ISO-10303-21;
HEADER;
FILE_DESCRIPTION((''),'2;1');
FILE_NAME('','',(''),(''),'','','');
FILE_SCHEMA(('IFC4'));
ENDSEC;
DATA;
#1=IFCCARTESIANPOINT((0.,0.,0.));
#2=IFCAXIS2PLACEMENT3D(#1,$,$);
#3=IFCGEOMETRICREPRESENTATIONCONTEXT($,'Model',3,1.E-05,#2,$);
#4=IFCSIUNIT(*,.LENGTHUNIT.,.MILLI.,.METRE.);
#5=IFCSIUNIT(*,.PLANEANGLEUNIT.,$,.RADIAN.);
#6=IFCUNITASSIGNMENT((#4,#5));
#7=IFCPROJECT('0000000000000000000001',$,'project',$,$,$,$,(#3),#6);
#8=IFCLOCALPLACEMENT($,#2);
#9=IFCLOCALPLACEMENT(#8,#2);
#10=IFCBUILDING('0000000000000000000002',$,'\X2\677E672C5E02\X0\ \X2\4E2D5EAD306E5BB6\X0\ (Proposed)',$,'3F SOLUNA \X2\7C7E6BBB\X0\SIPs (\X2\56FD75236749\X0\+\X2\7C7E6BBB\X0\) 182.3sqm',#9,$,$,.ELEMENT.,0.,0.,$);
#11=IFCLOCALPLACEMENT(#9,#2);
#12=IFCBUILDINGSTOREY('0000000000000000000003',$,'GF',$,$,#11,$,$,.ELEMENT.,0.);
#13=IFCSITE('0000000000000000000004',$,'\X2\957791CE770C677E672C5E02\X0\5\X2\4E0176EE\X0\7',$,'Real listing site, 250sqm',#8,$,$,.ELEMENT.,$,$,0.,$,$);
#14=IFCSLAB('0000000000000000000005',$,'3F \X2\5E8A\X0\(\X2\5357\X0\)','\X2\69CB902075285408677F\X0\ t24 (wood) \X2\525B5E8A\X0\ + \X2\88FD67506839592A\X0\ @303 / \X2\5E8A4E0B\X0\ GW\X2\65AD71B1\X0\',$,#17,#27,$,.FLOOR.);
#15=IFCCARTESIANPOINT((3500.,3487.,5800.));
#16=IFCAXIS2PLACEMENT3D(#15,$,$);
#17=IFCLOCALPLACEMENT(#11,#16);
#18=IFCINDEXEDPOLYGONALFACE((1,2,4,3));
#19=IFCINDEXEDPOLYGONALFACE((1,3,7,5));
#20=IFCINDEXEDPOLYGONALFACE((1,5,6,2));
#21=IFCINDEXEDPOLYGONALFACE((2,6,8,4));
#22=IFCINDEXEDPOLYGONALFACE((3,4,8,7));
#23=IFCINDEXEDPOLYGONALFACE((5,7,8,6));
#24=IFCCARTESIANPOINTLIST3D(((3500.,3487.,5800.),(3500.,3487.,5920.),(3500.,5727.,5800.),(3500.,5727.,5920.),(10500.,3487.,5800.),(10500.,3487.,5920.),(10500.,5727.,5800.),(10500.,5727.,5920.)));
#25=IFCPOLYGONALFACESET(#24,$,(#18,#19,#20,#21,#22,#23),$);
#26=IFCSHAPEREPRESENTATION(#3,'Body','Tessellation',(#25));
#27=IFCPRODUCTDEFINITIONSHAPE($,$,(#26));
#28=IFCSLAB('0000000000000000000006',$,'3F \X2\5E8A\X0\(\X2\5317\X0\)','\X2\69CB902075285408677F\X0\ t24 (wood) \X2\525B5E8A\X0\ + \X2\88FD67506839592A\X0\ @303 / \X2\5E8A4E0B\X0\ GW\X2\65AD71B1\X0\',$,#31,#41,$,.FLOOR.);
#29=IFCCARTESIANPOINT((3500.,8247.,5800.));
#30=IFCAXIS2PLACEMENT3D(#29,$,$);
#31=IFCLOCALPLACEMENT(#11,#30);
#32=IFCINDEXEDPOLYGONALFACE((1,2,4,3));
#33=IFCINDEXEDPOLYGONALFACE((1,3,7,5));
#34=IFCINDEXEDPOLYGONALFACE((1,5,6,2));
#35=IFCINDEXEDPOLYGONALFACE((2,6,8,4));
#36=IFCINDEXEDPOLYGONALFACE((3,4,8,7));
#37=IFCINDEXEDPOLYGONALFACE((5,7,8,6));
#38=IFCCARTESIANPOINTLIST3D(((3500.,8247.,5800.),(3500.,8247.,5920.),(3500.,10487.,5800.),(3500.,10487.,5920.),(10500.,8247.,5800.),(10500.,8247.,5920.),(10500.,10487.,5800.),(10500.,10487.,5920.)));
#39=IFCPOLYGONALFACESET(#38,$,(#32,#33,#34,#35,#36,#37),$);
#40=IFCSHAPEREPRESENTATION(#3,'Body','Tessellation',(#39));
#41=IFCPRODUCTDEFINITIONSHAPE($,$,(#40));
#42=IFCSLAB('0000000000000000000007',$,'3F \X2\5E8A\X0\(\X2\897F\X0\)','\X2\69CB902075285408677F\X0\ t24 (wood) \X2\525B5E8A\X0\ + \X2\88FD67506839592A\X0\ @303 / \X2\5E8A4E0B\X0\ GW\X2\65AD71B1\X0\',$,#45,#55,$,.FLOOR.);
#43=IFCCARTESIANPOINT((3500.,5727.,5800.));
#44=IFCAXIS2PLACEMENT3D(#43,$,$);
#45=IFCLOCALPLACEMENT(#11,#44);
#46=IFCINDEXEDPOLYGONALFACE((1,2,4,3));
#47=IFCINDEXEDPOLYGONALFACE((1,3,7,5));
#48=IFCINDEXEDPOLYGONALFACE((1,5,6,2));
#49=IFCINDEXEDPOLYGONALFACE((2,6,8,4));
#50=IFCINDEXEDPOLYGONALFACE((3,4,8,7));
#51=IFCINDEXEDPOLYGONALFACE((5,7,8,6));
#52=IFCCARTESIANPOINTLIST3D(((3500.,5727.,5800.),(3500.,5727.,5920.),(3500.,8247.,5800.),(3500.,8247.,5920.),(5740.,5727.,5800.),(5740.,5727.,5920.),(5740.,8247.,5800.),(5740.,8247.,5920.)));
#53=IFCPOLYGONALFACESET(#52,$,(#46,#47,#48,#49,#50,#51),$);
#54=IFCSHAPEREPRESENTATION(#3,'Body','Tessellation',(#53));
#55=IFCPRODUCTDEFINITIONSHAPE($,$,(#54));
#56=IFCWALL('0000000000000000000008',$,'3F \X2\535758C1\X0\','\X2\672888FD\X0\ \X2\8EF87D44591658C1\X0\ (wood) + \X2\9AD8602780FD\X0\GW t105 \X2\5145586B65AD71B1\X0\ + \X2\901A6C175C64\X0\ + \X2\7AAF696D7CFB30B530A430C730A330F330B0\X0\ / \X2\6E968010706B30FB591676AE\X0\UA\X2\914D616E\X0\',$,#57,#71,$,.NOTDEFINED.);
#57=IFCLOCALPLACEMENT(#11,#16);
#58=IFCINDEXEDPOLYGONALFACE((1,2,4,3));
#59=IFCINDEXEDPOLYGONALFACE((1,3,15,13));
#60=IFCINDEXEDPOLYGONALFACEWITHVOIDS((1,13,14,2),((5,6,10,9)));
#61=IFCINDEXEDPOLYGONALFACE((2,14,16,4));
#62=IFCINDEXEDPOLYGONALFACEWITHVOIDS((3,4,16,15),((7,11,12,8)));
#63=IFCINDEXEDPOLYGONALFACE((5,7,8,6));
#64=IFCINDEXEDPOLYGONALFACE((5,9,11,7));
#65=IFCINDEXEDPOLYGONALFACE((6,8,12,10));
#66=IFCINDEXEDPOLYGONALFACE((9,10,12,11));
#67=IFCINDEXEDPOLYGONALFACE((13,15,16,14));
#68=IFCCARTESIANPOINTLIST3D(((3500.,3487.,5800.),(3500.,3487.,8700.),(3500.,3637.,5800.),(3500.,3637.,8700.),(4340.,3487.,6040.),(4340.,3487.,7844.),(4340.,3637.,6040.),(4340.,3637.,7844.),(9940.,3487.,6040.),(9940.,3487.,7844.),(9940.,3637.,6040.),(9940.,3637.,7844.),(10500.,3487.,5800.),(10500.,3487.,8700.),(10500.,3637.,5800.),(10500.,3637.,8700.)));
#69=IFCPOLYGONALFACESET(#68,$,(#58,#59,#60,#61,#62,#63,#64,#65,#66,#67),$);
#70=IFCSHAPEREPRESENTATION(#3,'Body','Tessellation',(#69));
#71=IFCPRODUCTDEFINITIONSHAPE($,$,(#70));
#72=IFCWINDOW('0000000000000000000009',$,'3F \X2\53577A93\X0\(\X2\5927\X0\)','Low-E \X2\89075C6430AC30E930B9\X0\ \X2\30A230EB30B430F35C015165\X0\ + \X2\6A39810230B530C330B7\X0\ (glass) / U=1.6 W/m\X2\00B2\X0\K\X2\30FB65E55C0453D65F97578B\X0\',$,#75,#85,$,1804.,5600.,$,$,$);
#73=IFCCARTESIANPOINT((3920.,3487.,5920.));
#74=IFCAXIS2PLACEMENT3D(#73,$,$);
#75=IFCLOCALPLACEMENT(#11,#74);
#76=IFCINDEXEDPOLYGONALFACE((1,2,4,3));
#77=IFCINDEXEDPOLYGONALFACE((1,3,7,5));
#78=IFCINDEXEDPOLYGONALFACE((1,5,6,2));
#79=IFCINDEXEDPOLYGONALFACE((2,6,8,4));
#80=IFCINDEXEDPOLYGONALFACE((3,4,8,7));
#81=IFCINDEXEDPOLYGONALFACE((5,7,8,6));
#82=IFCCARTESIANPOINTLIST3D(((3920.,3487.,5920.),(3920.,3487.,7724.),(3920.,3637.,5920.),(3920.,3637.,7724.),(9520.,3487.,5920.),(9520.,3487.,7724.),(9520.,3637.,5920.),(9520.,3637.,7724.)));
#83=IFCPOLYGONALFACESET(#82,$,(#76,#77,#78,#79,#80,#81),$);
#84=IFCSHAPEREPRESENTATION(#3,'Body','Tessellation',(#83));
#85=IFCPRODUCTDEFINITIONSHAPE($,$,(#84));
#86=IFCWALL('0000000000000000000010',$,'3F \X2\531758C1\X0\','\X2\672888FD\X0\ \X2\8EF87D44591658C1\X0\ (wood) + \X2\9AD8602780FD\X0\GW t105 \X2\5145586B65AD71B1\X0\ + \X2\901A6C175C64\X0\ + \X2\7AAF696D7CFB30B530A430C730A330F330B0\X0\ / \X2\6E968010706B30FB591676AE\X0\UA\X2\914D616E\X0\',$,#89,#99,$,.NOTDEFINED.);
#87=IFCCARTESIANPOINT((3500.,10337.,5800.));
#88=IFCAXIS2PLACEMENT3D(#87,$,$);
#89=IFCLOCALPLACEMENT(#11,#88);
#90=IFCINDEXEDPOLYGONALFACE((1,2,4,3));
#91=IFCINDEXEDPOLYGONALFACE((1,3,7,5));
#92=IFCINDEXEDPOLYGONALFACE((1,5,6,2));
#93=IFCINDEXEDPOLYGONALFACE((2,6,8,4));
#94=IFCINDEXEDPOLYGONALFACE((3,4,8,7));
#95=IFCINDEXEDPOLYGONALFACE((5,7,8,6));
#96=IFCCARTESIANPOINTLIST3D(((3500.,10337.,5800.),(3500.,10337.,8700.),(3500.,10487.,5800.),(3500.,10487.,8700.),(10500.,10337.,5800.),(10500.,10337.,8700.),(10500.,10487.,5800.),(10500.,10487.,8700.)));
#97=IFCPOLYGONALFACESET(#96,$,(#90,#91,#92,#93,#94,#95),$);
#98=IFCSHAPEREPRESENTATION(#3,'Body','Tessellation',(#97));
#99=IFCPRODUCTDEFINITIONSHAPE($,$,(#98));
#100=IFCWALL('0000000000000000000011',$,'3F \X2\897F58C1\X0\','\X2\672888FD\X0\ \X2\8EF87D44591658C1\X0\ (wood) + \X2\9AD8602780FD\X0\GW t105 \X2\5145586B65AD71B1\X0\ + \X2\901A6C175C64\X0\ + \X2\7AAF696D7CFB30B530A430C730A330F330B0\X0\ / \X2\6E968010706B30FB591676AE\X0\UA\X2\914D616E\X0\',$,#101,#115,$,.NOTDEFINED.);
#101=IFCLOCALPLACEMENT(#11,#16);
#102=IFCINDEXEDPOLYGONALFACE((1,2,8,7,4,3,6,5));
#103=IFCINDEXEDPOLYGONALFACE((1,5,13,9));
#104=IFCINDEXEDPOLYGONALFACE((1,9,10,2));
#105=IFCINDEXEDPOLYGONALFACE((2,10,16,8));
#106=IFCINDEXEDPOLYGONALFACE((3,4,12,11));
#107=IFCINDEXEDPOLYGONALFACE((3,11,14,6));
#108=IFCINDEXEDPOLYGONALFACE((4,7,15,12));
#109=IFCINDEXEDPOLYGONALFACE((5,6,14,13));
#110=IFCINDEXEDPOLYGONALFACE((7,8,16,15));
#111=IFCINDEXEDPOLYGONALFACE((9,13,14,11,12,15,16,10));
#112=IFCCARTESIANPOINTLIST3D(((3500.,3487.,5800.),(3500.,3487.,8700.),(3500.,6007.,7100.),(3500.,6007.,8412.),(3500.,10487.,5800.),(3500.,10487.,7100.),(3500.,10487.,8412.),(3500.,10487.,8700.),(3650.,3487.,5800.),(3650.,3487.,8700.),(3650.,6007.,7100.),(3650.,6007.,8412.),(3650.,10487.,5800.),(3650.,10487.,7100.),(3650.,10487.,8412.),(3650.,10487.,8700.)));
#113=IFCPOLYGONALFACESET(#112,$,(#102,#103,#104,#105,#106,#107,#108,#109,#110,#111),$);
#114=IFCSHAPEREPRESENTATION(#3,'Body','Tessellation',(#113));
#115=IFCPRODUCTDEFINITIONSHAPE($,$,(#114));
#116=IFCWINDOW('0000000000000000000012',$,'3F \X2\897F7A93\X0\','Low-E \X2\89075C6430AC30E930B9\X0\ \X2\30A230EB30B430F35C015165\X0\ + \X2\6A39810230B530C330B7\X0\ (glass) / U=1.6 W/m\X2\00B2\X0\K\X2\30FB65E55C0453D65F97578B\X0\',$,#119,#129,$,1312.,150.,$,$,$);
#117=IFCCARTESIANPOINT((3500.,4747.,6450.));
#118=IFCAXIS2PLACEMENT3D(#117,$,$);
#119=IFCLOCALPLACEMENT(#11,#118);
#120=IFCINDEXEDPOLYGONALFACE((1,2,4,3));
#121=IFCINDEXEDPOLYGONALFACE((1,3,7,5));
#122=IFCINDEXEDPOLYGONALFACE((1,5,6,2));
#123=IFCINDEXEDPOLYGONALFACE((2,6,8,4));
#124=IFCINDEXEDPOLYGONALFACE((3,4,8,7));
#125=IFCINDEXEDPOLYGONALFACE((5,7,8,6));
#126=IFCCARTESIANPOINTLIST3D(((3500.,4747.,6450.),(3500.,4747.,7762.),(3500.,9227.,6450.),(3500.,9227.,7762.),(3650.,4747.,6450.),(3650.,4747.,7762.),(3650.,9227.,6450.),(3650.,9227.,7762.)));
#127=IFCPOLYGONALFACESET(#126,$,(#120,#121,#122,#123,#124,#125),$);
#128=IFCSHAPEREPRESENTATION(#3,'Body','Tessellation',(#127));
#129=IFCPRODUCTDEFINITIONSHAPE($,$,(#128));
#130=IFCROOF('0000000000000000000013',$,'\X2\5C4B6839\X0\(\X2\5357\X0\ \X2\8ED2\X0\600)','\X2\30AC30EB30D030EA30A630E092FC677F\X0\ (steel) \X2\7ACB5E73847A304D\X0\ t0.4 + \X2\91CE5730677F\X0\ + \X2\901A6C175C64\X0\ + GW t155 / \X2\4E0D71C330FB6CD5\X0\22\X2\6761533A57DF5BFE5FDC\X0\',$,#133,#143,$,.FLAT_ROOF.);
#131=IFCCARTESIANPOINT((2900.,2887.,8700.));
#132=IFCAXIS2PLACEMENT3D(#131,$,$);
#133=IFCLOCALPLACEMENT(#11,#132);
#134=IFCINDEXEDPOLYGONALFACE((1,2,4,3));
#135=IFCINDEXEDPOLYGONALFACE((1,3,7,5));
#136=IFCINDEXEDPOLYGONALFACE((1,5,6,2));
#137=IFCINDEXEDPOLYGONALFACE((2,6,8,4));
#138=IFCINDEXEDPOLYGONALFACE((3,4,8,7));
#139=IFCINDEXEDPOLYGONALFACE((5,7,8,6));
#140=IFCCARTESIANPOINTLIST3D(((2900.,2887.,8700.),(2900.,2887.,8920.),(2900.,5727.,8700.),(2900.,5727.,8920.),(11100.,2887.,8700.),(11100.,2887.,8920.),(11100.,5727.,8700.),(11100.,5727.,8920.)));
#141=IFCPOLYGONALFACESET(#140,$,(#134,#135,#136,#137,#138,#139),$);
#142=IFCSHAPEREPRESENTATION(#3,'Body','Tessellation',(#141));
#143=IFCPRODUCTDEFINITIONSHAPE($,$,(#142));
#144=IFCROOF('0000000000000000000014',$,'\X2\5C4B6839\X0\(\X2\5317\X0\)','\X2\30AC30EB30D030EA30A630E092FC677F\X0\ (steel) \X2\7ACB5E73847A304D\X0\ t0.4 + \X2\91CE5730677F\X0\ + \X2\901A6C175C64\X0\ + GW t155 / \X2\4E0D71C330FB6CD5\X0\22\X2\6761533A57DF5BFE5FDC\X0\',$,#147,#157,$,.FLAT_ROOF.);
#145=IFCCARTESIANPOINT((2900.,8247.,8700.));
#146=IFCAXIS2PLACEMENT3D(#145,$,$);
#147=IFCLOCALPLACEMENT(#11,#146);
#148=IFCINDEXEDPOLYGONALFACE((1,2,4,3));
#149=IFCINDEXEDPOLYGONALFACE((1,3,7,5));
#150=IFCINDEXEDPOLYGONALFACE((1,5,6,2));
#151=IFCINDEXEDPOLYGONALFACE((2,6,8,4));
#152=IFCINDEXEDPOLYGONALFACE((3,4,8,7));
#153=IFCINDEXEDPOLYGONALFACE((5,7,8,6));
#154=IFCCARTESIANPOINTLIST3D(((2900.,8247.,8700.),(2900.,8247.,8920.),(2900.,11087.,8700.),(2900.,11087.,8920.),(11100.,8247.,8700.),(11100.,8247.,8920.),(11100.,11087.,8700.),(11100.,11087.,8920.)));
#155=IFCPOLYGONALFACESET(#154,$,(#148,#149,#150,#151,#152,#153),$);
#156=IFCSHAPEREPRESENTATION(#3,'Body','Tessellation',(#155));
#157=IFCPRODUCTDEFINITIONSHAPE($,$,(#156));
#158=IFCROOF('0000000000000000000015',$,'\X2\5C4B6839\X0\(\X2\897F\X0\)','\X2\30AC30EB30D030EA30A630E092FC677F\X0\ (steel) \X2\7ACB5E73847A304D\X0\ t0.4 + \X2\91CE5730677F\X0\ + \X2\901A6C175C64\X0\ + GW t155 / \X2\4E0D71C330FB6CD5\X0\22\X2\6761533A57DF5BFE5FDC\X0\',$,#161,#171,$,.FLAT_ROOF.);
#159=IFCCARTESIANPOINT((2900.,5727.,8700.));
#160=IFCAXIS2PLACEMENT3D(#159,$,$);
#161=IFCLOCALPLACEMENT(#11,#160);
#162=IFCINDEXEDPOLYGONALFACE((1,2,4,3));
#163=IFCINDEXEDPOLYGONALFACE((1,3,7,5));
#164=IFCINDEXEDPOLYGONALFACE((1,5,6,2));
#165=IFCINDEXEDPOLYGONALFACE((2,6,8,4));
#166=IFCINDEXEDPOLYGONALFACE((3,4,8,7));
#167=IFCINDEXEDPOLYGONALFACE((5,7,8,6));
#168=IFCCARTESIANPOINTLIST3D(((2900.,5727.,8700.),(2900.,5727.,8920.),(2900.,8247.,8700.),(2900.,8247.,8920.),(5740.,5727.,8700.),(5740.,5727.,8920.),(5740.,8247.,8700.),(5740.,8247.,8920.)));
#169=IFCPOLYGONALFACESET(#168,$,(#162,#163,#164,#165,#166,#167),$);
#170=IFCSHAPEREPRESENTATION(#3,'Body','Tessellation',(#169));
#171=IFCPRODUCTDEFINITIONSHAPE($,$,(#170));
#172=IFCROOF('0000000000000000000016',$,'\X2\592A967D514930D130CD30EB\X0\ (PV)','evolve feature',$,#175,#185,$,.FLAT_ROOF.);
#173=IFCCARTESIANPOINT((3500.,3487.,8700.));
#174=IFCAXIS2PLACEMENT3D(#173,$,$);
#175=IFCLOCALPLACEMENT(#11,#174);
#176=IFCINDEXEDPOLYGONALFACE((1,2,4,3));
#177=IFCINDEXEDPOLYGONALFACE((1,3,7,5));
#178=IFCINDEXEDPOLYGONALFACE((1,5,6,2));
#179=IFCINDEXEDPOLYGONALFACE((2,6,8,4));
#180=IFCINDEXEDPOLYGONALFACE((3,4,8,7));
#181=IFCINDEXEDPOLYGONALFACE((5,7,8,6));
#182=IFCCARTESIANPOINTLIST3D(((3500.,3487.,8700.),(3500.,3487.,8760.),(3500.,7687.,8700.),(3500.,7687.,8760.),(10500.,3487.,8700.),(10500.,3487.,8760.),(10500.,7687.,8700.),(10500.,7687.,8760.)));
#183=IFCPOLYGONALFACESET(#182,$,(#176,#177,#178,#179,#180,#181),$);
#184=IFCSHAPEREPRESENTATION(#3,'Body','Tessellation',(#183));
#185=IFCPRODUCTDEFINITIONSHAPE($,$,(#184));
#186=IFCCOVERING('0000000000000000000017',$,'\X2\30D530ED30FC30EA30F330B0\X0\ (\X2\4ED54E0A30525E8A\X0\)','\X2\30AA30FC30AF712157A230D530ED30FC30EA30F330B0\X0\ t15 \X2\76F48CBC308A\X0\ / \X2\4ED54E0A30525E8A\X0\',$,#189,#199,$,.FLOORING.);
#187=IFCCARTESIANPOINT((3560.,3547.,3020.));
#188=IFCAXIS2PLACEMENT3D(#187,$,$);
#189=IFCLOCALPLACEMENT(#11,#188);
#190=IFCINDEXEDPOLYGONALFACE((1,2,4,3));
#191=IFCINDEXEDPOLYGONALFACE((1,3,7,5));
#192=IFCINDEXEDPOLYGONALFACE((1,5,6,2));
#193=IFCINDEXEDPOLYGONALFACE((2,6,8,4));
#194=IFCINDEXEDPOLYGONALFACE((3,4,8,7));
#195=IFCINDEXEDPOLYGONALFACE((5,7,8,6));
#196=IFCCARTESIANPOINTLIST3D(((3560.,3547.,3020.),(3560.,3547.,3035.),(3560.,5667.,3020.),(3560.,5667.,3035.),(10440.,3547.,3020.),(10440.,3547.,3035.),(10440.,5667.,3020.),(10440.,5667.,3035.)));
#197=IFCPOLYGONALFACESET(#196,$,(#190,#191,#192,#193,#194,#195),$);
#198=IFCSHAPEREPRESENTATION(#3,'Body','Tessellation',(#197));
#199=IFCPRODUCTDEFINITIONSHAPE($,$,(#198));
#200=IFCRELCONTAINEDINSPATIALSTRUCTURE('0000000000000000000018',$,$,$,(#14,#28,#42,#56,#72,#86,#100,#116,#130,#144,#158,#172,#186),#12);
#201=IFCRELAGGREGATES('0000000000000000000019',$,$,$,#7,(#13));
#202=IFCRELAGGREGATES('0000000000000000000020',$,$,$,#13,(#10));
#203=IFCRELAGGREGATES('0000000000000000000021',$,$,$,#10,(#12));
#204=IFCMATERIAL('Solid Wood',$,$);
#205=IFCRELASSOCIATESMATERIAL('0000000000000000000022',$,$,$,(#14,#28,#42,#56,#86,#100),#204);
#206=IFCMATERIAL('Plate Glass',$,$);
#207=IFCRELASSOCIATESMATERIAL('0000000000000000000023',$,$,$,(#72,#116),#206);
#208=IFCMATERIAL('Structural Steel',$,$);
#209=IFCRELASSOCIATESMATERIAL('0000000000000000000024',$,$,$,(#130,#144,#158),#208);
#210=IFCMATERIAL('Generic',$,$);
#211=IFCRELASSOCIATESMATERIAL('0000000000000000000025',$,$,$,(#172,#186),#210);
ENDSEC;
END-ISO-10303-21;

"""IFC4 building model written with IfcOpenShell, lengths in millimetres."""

from ifc_helpers import new_model, si_unit, frame, frame_2d, origin, place, context, project, spatial, rectangle, extrude, material, element, fill, save


model = new_model("IFC4")

# Units and contexts
model_context = context("Model", 3, precision=1e-05, world=origin())
ifc_project = project(units=[si_unit("LENGTHUNIT", "METRE", prefix="MILLI"), si_unit("PLANEANGLEUNIT", "RADIAN")], contexts=[model_context])

# Site, building, storey
site_placement = place(None, origin())
site = spatial("IfcSite", under=ifc_project, at=site_placement, Name="長野県松本市5丁目7", ObjectType="Real listing site, 250sqm", CompositionType="ELEMENT", RefElevation=0.0)
building_placement = place(site_placement, origin())
building = spatial("IfcBuilding", under=site, at=building_placement, Name="松本市 中庭の家 (Proposed)", ObjectType="3F SOLUNA 籾殻SIPs (国産杉+籾殻) 182.3sqm", CompositionType="ELEMENT", ElevationOfRefHeight=0.0, ElevationOfTerrain=0.0)
storey_placement = place(building_placement, origin())
storey = spatial("IfcBuildingStorey", under=building, at=storey_placement, Name="GF", CompositionType="ELEMENT", Elevation=0.0)

# Slabs
ifc_material_1 = material(Name="Solid Wood")
slab_1_placement = place(storey_placement, frame((3500.0, 3487.0, 5800.0)))
element("IfcSlab", 1, at=slab_1_placement, inside=storey, material=ifc_material_1, Name="3F 床(南)", Description="構造用合板 t24 (wood) 剛床 + 製材根太 @303 / 床下 GW断熱", PredefinedType="FLOOR", context=model_context, shape_type="SweptSolid", body=[
    extrude(rectangle(XDim=7000.0, YDim=2240.0, at=frame_2d((3500.0, 1120.0))), frame((3500.0, 3487.0, 5800.0)), (0.0, 0.0, 1.0), 120.0),
])
slab_2_placement = place(storey_placement, frame((3500.0, 8247.0, 5800.0)))
element("IfcSlab", 2, at=slab_2_placement, inside=storey, material=ifc_material_1, Name="3F 床(北)", Description="構造用合板 t24 (wood) 剛床 + 製材根太 @303 / 床下 GW断熱", PredefinedType="FLOOR", context=model_context, shape_type="SweptSolid", body=[
    extrude(rectangle(XDim=7000.0, YDim=2240.0, at=frame_2d((3500.0, 1120.0))), frame((3500.0, 8247.0, 5800.0)), (0.0, 0.0, 1.0), 120.0),
])
slab_3_placement = place(storey_placement, frame((3500.0, 5727.0, 5800.0)))
element("IfcSlab", 3, at=slab_3_placement, inside=storey, material=ifc_material_1, Name="3F 床(西)", Description="構造用合板 t24 (wood) 剛床 + 製材根太 @303 / 床下 GW断熱", PredefinedType="FLOOR", context=model_context, shape_type="SweptSolid", body=[
    extrude(rectangle(XDim=2240.0, YDim=2520.0, at=frame_2d((1120.0, 1260.0))), frame((3500.0, 5727.0, 5800.0)), (0.0, 0.0, 1.0), 120.0),
])

# Wall, opening, window
wall_1_placement = place(storey_placement, frame((3500.0, 3487.0, 5800.0)))
wall_1 = element("IfcWall", 4, at=wall_1_placement, inside=storey, material=ifc_material_1, Name="3F 南壁", Description="木製 軸組外壁 (wood) + 高性能GW t105 充填断熱 + 通気層 + 窯業系サイディング / 準耐火・外皮UA配慮", PredefinedType="NOTDEFINED", context=model_context, shape_type="SweptSolid", body=[
    extrude(rectangle(XDim=7000.0, YDim=150.0, at=frame_2d((3500.0, 75.0))), frame((3500.0, 3487.0, 5800.0)), (0.0, 0.0, 1.0), 2900.0),
])
opening_1_placement = place(storey_placement, frame((3920.0, 3487.0, 5920.0)))
opening_1 = element("IfcOpeningElement", 5, at=opening_1_placement, cuts=wall_1, PredefinedType="NOTDEFINED", context=model_context, shape_type="SweptSolid", body=[
    extrude(rectangle(XDim=5600.0, YDim=150.0, at=frame_2d((2800.0, 75.0))), frame((3920.0, 3487.0, 5920.0)), (0.0, 0.0, 1.0), 1804.0),
])
ifc_material_2 = material(Name="Plate Glass")
window_1_placement = place(storey_placement, frame((3920.0, 3487.0, 5920.0)))
window_1 = element("IfcWindow", 6, at=window_1_placement, inside=storey, material=ifc_material_2, Name="3F 南窓(大)", Description="Low-E 複層ガラス アルゴン封入 + 樹脂サッシ (glass) / U=1.6 W/m²K・日射取得型", OverallHeight=1804.0, OverallWidth=5600.0, context=model_context, shape_type="SweptSolid", body=[
    extrude(rectangle(XDim=5600.0, YDim=150.0, at=frame_2d((2800.0, 75.0))), frame((3920.0, 3487.0, 5920.0)), (0.0, 0.0, 1.0), 1804.0),
])
fill(opening_1, window_1)

# Wall
wall_2_placement = place(storey_placement, frame((3500.0, 10337.0, 5800.0)))
element("IfcWall", 7, at=wall_2_placement, inside=storey, material=ifc_material_1, Name="3F 北壁", Description="木製 軸組外壁 (wood) + 高性能GW t105 充填断熱 + 通気層 + 窯業系サイディング / 準耐火・外皮UA配慮", PredefinedType="NOTDEFINED", context=model_context, shape_type="SweptSolid", body=[
    extrude(rectangle(XDim=7000.0, YDim=150.0, at=frame_2d((3500.0, 75.0))), frame((3500.0, 10337.0, 5800.0)), (0.0, 0.0, 1.0), 2900.0),
])

# Wall, opening, window
wall_3_placement = place(storey_placement, frame((3500.0, 3487.0, 5800.0)))
wall_3 = element("IfcWall", 8, at=wall_3_placement, inside=storey, material=ifc_material_1, Name="3F 西壁", Description="木製 軸組外壁 (wood) + 高性能GW t105 充填断熱 + 通気層 + 窯業系サイディング / 準耐火・外皮UA配慮", PredefinedType="NOTDEFINED", context=model_context, shape_type="SweptSolid", body=[
    extrude(rectangle(XDim=150.0, YDim=7000.0, at=frame_2d((75.0, 3500.0))), frame((3500.0, 3487.0, 5800.0)), (0.0, 0.0, 1.0), 2900.0),
])
opening_2_placement = place(storey_placement, frame((3500.0, 4747.0, 6450.0)))
opening_2 = element("IfcOpeningElement", 9, at=opening_2_placement, cuts=wall_3, PredefinedType="NOTDEFINED", context=model_context, shape_type="SweptSolid", body=[
    extrude(rectangle(XDim=150.0, YDim=4480.0, at=frame_2d((75.0, 2240.0))), frame((3500.0, 4747.0, 6450.0)), (0.0, 0.0, 1.0), 1312.0),
])
window_2_placement = place(storey_placement, frame((3500.0, 4747.0, 6450.0)))
window_2 = element("IfcWindow", 10, at=window_2_placement, inside=storey, material=ifc_material_2, Name="3F 西窓", Description="Low-E 複層ガラス アルゴン封入 + 樹脂サッシ (glass) / U=1.6 W/m²K・日射取得型", OverallHeight=1312.0, OverallWidth=150.0, context=model_context, shape_type="SweptSolid", body=[
    extrude(rectangle(XDim=150.0, YDim=4480.0, at=frame_2d((75.0, 2240.0))), frame((3500.0, 4747.0, 6450.0)), (0.0, 0.0, 1.0), 1312.0),
])
fill(opening_2, window_2)

# Roofs
ifc_material_3 = material(Name="Structural Steel")
roof_1_placement = place(storey_placement, frame((2900.0, 2887.0, 8700.0)))
element("IfcRoof", 11, at=roof_1_placement, inside=storey, material=ifc_material_3, Name="屋根(南 軒600)", Description="ガルバリウム鋼板 (steel) 立平葺き t0.4 + 野地板 + 通気層 + GW t155 / 不燃・法22条区域対応", PredefinedType="FLAT_ROOF", context=model_context, shape_type="SweptSolid", body=[
    extrude(rectangle(XDim=8200.0, YDim=2840.0, at=frame_2d((4100.0, 1420.0))), frame((2900.0, 2887.0, 8700.0)), (0.0, 0.0, 1.0), 220.0),
])
roof_2_placement = place(storey_placement, frame((2900.0, 8247.0, 8700.0)))
element("IfcRoof", 12, at=roof_2_placement, inside=storey, material=ifc_material_3, Name="屋根(北)", Description="ガルバリウム鋼板 (steel) 立平葺き t0.4 + 野地板 + 通気層 + GW t155 / 不燃・法22条区域対応", PredefinedType="FLAT_ROOF", context=model_context, shape_type="SweptSolid", body=[
    extrude(rectangle(XDim=8200.0, YDim=2840.0, at=frame_2d((4100.0, 1420.0))), frame((2900.0, 8247.0, 8700.0)), (0.0, 0.0, 1.0), 220.0),
])
roof_3_placement = place(storey_placement, frame((2900.0, 5727.0, 8700.0)))
element("IfcRoof", 13, at=roof_3_placement, inside=storey, material=ifc_material_3, Name="屋根(西)", Description="ガルバリウム鋼板 (steel) 立平葺き t0.4 + 野地板 + 通気層 + GW t155 / 不燃・法22条区域対応", PredefinedType="FLAT_ROOF", context=model_context, shape_type="SweptSolid", body=[
    extrude(rectangle(XDim=2840.0, YDim=2520.0, at=frame_2d((1420.0, 1260.0))), frame((2900.0, 5727.0, 8700.0)), (0.0, 0.0, 1.0), 220.0),
])
ifc_material_4 = material(Name="Generic")
roof_4_placement = place(storey_placement, frame((3500.0, 3487.0, 8700.0)))
element("IfcRoof", 14, at=roof_4_placement, inside=storey, material=ifc_material_4, Name="太陽光パネル (PV)", Description="evolve feature", PredefinedType="FLAT_ROOF", context=model_context, shape_type="SweptSolid", body=[
    extrude(rectangle(XDim=7000.0, YDim=4200.0, at=frame_2d((3500.0, 2100.0))), frame((3500.0, 3487.0, 8700.0)), (0.0, 0.0, 1.0), 60.0),
])

# Covering
covering_1_placement = place(storey_placement, frame((3560.0, 3547.0, 3020.0)))
element("IfcCovering", 15, at=covering_1_placement, inside=storey, material=ifc_material_4, Name="フローリング (仕上げ床)", Description="オーク無垢フローリング t15 直貼り / 仕上げ床", PredefinedType="FLOORING", context=model_context, shape_type="SweptSolid", body=[
    extrude(rectangle(XDim=6880.0, YDim=2120.0, at=frame_2d((3440.0, 1060.0))), frame((3560.0, 3547.0, 3020.0)), (0.0, 0.0, 1.0), 15.0),
])

save(model, "model.ifc")
